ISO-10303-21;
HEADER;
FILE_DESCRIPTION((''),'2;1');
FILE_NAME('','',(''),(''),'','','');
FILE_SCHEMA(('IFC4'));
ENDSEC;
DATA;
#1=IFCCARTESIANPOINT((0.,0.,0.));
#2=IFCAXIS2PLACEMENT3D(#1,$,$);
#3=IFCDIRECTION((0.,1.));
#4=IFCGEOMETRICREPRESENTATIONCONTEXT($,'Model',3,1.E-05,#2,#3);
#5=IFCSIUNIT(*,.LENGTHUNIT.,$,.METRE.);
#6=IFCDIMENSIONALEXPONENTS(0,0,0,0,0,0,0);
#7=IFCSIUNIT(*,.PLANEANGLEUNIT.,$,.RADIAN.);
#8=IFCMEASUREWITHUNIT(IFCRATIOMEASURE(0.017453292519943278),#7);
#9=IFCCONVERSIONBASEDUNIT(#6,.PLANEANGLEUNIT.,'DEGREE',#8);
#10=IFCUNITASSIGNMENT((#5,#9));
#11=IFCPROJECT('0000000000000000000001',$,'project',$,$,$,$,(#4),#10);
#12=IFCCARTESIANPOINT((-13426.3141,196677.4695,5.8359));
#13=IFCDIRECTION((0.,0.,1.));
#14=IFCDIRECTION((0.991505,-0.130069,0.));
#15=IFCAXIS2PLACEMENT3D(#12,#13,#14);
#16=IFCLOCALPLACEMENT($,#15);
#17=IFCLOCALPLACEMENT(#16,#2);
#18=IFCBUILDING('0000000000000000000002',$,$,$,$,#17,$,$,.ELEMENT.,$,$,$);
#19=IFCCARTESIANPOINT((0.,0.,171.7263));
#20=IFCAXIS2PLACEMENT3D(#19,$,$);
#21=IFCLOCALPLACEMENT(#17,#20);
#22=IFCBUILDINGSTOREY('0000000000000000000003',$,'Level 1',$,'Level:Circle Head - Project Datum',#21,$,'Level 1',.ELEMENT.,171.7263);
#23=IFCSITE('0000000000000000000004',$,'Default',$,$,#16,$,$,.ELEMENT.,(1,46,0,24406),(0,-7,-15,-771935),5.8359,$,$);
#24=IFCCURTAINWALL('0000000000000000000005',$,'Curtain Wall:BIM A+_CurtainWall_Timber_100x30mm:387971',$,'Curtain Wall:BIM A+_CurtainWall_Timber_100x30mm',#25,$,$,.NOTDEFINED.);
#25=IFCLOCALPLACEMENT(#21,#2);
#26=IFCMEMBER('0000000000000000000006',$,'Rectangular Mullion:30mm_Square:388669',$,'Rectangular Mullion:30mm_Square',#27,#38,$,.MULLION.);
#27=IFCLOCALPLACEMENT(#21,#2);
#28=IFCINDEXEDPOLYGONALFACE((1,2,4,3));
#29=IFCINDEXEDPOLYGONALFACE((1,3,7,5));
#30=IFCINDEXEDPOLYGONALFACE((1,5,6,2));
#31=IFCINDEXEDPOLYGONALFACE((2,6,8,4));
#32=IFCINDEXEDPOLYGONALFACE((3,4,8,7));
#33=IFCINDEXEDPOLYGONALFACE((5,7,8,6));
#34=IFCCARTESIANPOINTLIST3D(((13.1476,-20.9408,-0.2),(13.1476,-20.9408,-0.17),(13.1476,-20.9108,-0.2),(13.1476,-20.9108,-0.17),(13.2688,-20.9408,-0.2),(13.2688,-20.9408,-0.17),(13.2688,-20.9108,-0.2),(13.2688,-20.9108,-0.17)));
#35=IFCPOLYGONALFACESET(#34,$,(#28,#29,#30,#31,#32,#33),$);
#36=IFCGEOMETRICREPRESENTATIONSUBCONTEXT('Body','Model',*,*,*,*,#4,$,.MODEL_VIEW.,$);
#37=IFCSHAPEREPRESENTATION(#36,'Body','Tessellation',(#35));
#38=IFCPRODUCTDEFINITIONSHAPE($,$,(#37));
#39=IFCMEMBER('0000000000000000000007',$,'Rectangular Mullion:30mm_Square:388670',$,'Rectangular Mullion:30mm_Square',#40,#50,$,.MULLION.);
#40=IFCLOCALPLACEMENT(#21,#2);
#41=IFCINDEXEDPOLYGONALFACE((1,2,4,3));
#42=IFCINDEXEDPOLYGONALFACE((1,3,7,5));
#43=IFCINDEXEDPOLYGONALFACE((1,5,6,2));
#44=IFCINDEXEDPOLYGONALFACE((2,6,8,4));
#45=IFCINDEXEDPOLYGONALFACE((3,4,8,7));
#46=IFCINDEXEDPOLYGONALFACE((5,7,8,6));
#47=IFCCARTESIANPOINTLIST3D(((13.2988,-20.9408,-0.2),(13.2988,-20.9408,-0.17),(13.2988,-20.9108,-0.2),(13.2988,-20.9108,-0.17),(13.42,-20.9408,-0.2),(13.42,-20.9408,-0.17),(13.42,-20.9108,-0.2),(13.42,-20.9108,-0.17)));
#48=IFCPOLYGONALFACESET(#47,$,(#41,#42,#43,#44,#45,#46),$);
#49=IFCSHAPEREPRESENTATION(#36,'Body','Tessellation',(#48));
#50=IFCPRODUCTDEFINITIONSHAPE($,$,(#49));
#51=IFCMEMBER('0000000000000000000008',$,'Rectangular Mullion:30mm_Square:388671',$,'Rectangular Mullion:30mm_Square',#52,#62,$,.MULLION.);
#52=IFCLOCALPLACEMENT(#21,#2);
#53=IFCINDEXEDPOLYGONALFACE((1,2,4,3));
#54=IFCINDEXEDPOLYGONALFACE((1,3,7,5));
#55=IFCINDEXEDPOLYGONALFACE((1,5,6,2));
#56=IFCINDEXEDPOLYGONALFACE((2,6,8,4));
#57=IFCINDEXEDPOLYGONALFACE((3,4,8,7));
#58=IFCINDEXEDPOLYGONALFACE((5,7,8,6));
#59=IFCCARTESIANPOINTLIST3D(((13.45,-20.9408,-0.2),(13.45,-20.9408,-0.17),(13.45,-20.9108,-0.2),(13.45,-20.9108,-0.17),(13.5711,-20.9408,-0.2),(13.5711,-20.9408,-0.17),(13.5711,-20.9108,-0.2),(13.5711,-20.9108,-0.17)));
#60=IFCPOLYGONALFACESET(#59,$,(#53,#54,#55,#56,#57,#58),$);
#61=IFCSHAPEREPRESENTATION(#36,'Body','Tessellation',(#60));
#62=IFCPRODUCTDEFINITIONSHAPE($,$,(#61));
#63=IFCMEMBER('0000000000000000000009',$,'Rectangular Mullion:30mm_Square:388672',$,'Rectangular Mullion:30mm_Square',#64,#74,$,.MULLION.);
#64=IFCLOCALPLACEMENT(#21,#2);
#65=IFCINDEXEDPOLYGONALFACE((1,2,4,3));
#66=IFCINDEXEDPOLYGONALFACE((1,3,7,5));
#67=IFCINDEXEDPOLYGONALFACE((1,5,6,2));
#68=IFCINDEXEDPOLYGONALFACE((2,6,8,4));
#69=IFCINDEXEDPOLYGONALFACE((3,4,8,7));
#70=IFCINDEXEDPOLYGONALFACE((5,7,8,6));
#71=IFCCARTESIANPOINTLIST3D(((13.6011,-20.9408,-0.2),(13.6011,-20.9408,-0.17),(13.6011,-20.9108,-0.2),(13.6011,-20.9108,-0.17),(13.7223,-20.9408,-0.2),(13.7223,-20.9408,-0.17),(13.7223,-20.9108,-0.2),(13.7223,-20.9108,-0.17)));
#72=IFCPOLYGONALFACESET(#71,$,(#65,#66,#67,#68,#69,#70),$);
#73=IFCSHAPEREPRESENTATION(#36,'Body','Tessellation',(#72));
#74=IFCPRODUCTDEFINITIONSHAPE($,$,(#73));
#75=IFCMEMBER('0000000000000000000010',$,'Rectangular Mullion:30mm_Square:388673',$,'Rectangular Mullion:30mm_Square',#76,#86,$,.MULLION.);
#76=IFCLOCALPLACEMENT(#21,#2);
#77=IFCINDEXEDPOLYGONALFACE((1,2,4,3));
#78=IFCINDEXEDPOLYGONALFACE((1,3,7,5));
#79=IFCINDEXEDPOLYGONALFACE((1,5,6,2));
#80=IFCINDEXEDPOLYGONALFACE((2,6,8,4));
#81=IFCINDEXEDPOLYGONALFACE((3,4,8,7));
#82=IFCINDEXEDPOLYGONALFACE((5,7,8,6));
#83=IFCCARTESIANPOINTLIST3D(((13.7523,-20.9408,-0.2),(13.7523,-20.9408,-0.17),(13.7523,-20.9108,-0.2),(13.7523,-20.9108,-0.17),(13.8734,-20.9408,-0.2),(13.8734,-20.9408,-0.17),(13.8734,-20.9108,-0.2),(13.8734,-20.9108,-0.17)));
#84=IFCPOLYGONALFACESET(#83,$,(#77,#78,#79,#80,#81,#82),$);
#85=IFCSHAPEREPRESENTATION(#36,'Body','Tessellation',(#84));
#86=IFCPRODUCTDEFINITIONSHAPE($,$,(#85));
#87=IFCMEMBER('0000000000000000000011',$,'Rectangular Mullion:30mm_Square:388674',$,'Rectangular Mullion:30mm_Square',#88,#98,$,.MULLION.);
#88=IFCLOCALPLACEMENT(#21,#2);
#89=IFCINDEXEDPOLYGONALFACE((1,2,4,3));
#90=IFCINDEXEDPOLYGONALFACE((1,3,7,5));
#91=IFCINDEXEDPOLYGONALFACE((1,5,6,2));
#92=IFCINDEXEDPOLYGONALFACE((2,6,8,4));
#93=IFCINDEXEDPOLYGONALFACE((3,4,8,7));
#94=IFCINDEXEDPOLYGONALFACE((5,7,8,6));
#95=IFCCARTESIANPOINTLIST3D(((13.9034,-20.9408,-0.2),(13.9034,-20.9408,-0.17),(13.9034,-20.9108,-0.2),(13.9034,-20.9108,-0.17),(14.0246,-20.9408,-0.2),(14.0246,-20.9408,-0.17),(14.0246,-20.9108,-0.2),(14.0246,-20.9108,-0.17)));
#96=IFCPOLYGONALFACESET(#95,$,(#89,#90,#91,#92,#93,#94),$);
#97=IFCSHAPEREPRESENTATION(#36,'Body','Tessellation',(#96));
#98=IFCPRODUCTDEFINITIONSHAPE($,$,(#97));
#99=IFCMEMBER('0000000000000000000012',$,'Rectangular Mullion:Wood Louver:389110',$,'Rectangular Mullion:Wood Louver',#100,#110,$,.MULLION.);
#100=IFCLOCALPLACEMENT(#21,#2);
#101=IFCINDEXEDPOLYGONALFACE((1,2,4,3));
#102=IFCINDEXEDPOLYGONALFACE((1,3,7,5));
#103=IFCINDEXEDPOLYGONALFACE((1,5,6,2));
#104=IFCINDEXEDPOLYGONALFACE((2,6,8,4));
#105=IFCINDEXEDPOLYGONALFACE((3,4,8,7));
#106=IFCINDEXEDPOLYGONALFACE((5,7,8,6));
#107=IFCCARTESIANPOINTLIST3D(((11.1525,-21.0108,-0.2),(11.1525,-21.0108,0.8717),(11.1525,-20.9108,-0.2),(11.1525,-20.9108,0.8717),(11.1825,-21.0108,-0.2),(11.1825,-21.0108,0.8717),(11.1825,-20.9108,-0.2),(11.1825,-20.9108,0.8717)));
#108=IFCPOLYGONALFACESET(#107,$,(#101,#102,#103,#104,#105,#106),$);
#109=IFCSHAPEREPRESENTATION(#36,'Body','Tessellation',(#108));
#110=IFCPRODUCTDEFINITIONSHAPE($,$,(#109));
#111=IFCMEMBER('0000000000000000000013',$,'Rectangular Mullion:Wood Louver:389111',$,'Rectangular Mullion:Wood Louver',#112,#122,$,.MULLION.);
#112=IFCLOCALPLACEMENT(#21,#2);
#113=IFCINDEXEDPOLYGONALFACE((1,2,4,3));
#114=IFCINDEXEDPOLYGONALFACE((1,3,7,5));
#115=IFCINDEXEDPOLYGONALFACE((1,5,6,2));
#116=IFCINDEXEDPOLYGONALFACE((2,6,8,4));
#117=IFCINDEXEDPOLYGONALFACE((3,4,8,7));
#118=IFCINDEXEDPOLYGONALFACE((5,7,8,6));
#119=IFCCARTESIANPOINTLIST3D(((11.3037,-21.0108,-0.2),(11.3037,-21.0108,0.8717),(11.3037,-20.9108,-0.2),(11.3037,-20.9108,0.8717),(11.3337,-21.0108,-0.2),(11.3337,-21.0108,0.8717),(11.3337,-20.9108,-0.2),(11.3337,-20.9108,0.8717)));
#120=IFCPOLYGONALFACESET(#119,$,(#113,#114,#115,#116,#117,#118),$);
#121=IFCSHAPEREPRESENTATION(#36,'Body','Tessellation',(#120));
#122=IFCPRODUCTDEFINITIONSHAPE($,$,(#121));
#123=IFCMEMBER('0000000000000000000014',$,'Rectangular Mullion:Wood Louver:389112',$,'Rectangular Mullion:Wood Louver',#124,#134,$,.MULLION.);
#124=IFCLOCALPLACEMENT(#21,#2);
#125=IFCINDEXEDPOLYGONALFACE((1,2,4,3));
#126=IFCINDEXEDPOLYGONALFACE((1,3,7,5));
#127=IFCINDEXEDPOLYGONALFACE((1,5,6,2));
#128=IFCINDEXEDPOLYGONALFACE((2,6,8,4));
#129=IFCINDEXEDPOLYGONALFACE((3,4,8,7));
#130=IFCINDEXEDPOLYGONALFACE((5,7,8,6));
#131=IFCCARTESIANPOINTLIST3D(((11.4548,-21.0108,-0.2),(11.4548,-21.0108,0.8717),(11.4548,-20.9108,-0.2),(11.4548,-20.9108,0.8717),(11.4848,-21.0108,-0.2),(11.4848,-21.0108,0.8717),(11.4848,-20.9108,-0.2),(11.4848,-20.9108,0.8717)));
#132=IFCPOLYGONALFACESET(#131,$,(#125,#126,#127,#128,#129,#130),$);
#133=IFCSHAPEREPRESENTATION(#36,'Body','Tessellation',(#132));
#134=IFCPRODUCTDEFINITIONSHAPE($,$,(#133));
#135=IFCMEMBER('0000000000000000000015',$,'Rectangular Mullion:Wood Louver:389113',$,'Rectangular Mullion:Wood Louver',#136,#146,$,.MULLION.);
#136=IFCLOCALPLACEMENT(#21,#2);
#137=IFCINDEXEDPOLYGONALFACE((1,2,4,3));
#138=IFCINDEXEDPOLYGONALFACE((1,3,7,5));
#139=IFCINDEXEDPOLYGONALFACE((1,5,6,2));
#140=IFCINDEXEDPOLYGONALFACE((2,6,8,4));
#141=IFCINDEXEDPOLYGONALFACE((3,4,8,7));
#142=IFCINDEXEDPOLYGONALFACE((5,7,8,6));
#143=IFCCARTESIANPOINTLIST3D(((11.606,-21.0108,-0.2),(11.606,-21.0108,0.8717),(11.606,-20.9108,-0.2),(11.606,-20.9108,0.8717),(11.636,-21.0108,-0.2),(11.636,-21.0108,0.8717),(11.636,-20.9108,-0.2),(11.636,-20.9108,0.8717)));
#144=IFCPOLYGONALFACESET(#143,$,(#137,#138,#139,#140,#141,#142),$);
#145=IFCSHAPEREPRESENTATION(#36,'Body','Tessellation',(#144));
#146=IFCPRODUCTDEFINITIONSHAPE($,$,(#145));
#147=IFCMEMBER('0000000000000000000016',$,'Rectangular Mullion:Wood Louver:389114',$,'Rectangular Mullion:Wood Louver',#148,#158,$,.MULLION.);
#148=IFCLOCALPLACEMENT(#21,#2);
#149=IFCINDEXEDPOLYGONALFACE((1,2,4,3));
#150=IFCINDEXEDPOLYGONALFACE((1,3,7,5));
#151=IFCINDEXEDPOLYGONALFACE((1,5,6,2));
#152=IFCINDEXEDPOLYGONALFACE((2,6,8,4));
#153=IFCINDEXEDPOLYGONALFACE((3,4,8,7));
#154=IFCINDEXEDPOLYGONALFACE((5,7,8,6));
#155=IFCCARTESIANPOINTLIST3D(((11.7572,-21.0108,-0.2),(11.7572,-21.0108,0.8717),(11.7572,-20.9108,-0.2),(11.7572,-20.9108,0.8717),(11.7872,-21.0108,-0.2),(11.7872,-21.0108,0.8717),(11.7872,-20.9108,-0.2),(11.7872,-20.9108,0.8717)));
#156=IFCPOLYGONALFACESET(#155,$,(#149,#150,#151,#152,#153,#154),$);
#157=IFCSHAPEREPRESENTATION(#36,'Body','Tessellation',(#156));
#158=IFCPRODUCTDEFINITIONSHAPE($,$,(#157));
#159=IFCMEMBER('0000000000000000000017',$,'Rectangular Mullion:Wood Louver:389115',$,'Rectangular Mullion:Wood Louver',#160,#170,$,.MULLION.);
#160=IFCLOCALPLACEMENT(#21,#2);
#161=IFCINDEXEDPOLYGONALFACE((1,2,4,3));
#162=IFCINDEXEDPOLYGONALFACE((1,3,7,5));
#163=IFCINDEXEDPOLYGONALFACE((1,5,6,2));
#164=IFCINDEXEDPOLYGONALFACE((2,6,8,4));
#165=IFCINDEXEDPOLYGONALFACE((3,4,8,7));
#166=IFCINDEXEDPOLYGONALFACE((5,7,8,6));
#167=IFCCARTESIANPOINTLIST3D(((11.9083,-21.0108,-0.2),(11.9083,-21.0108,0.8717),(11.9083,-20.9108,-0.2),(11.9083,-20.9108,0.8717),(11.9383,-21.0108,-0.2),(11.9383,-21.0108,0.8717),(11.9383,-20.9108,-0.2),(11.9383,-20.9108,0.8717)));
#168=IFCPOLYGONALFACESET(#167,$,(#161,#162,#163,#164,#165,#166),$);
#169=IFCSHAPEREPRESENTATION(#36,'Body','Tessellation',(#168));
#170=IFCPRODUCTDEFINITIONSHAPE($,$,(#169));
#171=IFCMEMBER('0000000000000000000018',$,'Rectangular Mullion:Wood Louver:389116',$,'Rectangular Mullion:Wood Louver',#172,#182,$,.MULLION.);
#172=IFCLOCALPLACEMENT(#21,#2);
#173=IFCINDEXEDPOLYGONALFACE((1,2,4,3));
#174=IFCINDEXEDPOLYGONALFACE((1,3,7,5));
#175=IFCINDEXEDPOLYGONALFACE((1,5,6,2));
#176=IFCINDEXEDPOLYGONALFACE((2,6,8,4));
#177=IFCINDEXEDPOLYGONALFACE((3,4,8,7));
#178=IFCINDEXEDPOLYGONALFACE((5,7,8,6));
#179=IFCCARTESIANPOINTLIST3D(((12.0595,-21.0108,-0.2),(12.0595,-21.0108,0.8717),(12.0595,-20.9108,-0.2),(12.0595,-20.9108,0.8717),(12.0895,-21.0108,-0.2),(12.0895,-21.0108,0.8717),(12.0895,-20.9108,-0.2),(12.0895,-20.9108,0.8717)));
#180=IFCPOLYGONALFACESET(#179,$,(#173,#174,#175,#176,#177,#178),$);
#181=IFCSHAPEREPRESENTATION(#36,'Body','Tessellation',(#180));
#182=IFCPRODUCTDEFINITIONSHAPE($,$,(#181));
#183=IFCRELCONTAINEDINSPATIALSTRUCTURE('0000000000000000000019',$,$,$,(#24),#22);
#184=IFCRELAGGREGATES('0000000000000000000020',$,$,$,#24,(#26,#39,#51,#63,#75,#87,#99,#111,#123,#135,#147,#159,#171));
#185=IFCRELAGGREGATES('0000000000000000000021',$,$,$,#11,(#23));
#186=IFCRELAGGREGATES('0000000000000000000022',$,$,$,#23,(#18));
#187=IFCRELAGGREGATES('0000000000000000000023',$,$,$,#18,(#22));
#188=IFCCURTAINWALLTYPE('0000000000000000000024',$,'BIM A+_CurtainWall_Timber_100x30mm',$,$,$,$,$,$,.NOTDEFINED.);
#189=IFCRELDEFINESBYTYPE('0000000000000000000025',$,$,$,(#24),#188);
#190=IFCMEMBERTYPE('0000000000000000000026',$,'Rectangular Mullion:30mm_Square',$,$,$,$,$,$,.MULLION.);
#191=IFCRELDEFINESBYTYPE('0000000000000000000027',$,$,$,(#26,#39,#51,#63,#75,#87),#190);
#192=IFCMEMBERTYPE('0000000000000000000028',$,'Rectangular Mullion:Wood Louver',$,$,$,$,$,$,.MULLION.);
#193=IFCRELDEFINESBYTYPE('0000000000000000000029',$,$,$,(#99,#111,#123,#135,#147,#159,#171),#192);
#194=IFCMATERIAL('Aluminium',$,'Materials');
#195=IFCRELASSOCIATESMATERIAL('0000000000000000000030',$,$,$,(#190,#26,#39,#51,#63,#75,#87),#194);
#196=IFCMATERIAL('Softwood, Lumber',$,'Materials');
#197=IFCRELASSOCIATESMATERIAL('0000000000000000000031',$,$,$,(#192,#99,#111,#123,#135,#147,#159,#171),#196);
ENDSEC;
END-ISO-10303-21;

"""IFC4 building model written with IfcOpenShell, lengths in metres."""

from ifc_helpers import new_model, entity, si_unit, converted_unit, direction, frame, origin, place, context, subcontext, project, spatial, indexed_curve, outline, extrude, source, transform, mapped, material, type_object, type_shapes, element, aggregate, save


model = new_model("IFC4")

# Units and contexts
model_context = context("Model", 3, precision=1e-05, world=origin(), true_north=direction((0.0, 1.0)))
body_context = subcontext(model_context, "Body", "Model", "MODEL_VIEW")
ifc_project = project(units=[si_unit("LENGTHUNIT", "METRE"), converted_unit("PLANEANGLEUNIT", "DEGREE", entity("IfcRatioMeasure", 0.017453292519943278), si_unit("PLANEANGLEUNIT", "RADIAN"), dimensions=[0, 0, 0, 0, 0, 0, 0])], contexts=[model_context])

# Site, building, storey
site_placement = place(None, frame((-13426.3141, 196677.4695, 5.8359), z_axis=(0.0, 0.0, 1.0), x_axis=(0.991505, -0.130069, 0.0)))
site = spatial("IfcSite", under=ifc_project, at=site_placement, Name="Default", CompositionType="ELEMENT", RefLatitude=(1, 46, 0, 24406), RefLongitude=(0, -7, -15, -771935), RefElevation=5.8359)
building_placement = place(site_placement, origin())
building = spatial("IfcBuilding", under=site, at=building_placement, CompositionType="ELEMENT")
storey_placement = place(building_placement, frame((0.0, 0.0, 171.7263)))
storey = spatial("IfcBuildingStorey", under=building, at=storey_placement, Name="Level 1", ObjectType="Level:Circle Head - Project Datum", LongName="Level 1", CompositionType="ELEMENT", Elevation=171.7263)

# Curtain wall, members
curtain_wall_type = type_object("IfcCurtainWallType", Name="BIM A+_CurtainWall_Timber_100x30mm", PredefinedType="NOTDEFINED")
curtain_wall_placement = place(storey_placement, frame((0.0, 0.0, -171.7263)))
curtain_wall = element("IfcCurtainWall", 1, at=curtain_wall_placement, inside=storey, type_object=curtain_wall_type, Name="Curtain Wall:BIM A+_CurtainWall_Timber_100x30mm:387971", ObjectType="Curtain Wall:BIM A+_CurtainWall_Timber_100x30mm", PredefinedType="NOTDEFINED")
ifc_material_1 = material(Name="Aluminium", Category="Materials")
member_type_1 = type_object("IfcMemberType", Name="Rectangular Mullion:30mm_Square", PredefinedType="MULLION", material=ifc_material_1)
shared_shape_1 = source(origin(), body_context, "Body", "SweptSolid", [
    extrude(outline(indexed_curve([(-0.015, -0.015), (0.015, -0.015), (0.015, 0.015), (-0.015, 0.015), (-0.015, -0.015)], self_intersect=False)), frame((-0.015, 0.0, -0.1212), z_axis=(0.0, 0.0, 1.0), x_axis=(0.0, -1.0, 0.0)), (0.0, 0.0, 1.0), 0.1212),
])
type_shapes(member_type_1, [shared_shape_1])
member_1_placement = place(curtain_wall_placement, frame((13.1476, -20.9258, 171.5263), z_axis=(-1.0, 0.0, 0.0), x_axis=(0.0, 0.0, -1.0)))
member_1 = element("IfcMember", 2, at=member_1_placement, type_object=member_type_1, material=ifc_material_1, Name="Rectangular Mullion:30mm_Square:388669", ObjectType="Rectangular Mullion:30mm_Square", PredefinedType="MULLION", context=body_context, shape_type="MappedRepresentation", body=[
    mapped(shared_shape_1, transform((0.0, 0.0, 0.0), scale=1.0)),
])
member_2_placement = place(curtain_wall_placement, frame((13.2988, -20.9258, 171.5263), z_axis=(-1.0, 0.0, 0.0), x_axis=(0.0, 0.0, -1.0)))
member_2 = element("IfcMember", 3, at=member_2_placement, type_object=member_type_1, material=ifc_material_1, Name="Rectangular Mullion:30mm_Square:388670", ObjectType="Rectangular Mullion:30mm_Square", PredefinedType="MULLION", context=body_context, shape_type="MappedRepresentation", body=[
    mapped(shared_shape_1, transform((0.0, 0.0, 0.0), scale=1.0)),
])
member_3_placement = place(curtain_wall_placement, frame((13.45, -20.9258, 171.5263), z_axis=(-1.0, 0.0, 0.0), x_axis=(0.0, 0.0, -1.0)))
member_3 = element("IfcMember", 4, at=member_3_placement, type_object=member_type_1, material=ifc_material_1, Name="Rectangular Mullion:30mm_Square:388671", ObjectType="Rectangular Mullion:30mm_Square", PredefinedType="MULLION", context=body_context, shape_type="MappedRepresentation", body=[
    mapped(shared_shape_1, transform((0.0, 0.0, 0.0), scale=1.0)),
])
member_4_placement = place(curtain_wall_placement, frame((13.6011, -20.9258, 171.5263), z_axis=(-1.0, 0.0, 0.0), x_axis=(0.0, 0.0, -1.0)))
member_4 = element("IfcMember", 5, at=member_4_placement, type_object=member_type_1, material=ifc_material_1, Name="Rectangular Mullion:30mm_Square:388672", ObjectType="Rectangular Mullion:30mm_Square", PredefinedType="MULLION", context=body_context, shape_type="MappedRepresentation", body=[
    mapped(shared_shape_1, transform((0.0, 0.0, 0.0), scale=1.0)),
])
member_5_placement = place(curtain_wall_placement, frame((13.7523, -20.9258, 171.5263), z_axis=(-1.0, 0.0, 0.0), x_axis=(0.0, 0.0, -1.0)))
member_5 = element("IfcMember", 6, at=member_5_placement, type_object=member_type_1, material=ifc_material_1, Name="Rectangular Mullion:30mm_Square:388673", ObjectType="Rectangular Mullion:30mm_Square", PredefinedType="MULLION", context=body_context, shape_type="MappedRepresentation", body=[
    mapped(shared_shape_1, transform((0.0, 0.0, 0.0), scale=1.0)),
])
member_6_placement = place(curtain_wall_placement, frame((13.9034, -20.9258, 171.5263), z_axis=(-1.0, 0.0, 0.0), x_axis=(0.0, 0.0, -1.0)))
member_6 = element("IfcMember", 7, at=member_6_placement, type_object=member_type_1, material=ifc_material_1, Name="Rectangular Mullion:30mm_Square:388674", ObjectType="Rectangular Mullion:30mm_Square", PredefinedType="MULLION", context=body_context, shape_type="MappedRepresentation", body=[
    mapped(shared_shape_1, transform((0.0, 0.0, 0.0), scale=1.0)),
])
ifc_material_2 = material(Name="Softwood, Lumber", Category="Materials")
member_type_2 = type_object("IfcMemberType", Name="Rectangular Mullion:Wood Louver", PredefinedType="MULLION", material=ifc_material_2)
shared_shape_2 = source(origin(), body_context, "Body", "SweptSolid", [
    extrude(outline(indexed_curve([(-0.05, -0.015), (0.05, -0.015), (0.05, 0.015), (-0.05, 0.015), (-0.05, -0.015)], self_intersect=False)), frame((0.0, 0.035, -1.0717), z_axis=(0.0, 0.0, 1.0), x_axis=(0.0, -1.0, 0.0)), (0.0, 0.0, 1.0), 1.0717),
])
type_shapes(member_type_2, [shared_shape_2])
member_7_placement = place(curtain_wall_placement, frame((11.1675, -20.9258, 171.5263), z_axis=(0.0, 0.0, -1.0), x_axis=(1.0, 0.0, 0.0)))
member_7 = element("IfcMember", 8, at=member_7_placement, type_object=member_type_2, material=ifc_material_2, Name="Rectangular Mullion:Wood Louver:389110", ObjectType="Rectangular Mullion:Wood Louver", PredefinedType="MULLION", context=body_context, shape_type="MappedRepresentation", body=[
    mapped(shared_shape_2, transform((0.0, 0.0, 0.0), scale=1.0)),
])
member_8_placement = place(curtain_wall_placement, frame((11.3187, -20.9258, 171.5263), z_axis=(0.0, 0.0, -1.0), x_axis=(1.0, 0.0, 0.0)))
member_8 = element("IfcMember", 9, at=member_8_placement, type_object=member_type_2, material=ifc_material_2, Name="Rectangular Mullion:Wood Louver:389111", ObjectType="Rectangular Mullion:Wood Louver", PredefinedType="MULLION", context=body_context, shape_type="MappedRepresentation", body=[
    mapped(shared_shape_2, transform((0.0, 0.0, 0.0), scale=1.0)),
])
member_9_placement = place(curtain_wall_placement, frame((11.4698, -20.9258, 171.5263), z_axis=(0.0, 0.0, -1.0), x_axis=(1.0, 0.0, 0.0)))
member_9 = element("IfcMember", 10, at=member_9_placement, type_object=member_type_2, material=ifc_material_2, Name="Rectangular Mullion:Wood Louver:389112", ObjectType="Rectangular Mullion:Wood Louver", PredefinedType="MULLION", context=body_context, shape_type="MappedRepresentation", body=[
    mapped(shared_shape_2, transform((0.0, 0.0, 0.0), scale=1.0)),
])
member_10_placement = place(curtain_wall_placement, frame((11.621, -20.9258, 171.5263), z_axis=(0.0, 0.0, -1.0), x_axis=(1.0, 0.0, 0.0)))
member_10 = element("IfcMember", 11, at=member_10_placement, type_object=member_type_2, material=ifc_material_2, Name="Rectangular Mullion:Wood Louver:389113", ObjectType="Rectangular Mullion:Wood Louver", PredefinedType="MULLION", context=body_context, shape_type="MappedRepresentation", body=[
    mapped(shared_shape_2, transform((0.0, 0.0, 0.0), scale=1.0)),
])
member_11_placement = place(curtain_wall_placement, frame((11.7722, -20.9258, 171.5263), z_axis=(0.0, 0.0, -1.0), x_axis=(1.0, 0.0, 0.0)))
member_11 = element("IfcMember", 12, at=member_11_placement, type_object=member_type_2, material=ifc_material_2, Name="Rectangular Mullion:Wood Louver:389114", ObjectType="Rectangular Mullion:Wood Louver", PredefinedType="MULLION", context=body_context, shape_type="MappedRepresentation", body=[
    mapped(shared_shape_2, transform((0.0, 0.0, 0.0), scale=1.0)),
])
member_12_placement = place(curtain_wall_placement, frame((11.9233, -20.9258, 171.5263), z_axis=(0.0, 0.0, -1.0), x_axis=(1.0, 0.0, 0.0)))
member_12 = element("IfcMember", 13, at=member_12_placement, type_object=member_type_2, material=ifc_material_2, Name="Rectangular Mullion:Wood Louver:389115", ObjectType="Rectangular Mullion:Wood Louver", PredefinedType="MULLION", context=body_context, shape_type="MappedRepresentation", body=[
    mapped(shared_shape_2, transform((0.0, 0.0, 0.0), scale=1.0)),
])
member_13_placement = place(curtain_wall_placement, frame((12.0745, -20.9258, 171.5263), z_axis=(0.0, 0.0, -1.0), x_axis=(1.0, 0.0, 0.0)))
member_13 = element("IfcMember", 14, at=member_13_placement, type_object=member_type_2, material=ifc_material_2, Name="Rectangular Mullion:Wood Louver:389116", ObjectType="Rectangular Mullion:Wood Louver", PredefinedType="MULLION", context=body_context, shape_type="MappedRepresentation", body=[
    mapped(shared_shape_2, transform((0.0, 0.0, 0.0), scale=1.0)),
])
aggregate(curtain_wall, [member_1, member_2, member_3, member_4, member_5, member_6, member_7, member_8, member_9, member_10, member_11, member_12, member_13])

save(model, "model.ifc")
